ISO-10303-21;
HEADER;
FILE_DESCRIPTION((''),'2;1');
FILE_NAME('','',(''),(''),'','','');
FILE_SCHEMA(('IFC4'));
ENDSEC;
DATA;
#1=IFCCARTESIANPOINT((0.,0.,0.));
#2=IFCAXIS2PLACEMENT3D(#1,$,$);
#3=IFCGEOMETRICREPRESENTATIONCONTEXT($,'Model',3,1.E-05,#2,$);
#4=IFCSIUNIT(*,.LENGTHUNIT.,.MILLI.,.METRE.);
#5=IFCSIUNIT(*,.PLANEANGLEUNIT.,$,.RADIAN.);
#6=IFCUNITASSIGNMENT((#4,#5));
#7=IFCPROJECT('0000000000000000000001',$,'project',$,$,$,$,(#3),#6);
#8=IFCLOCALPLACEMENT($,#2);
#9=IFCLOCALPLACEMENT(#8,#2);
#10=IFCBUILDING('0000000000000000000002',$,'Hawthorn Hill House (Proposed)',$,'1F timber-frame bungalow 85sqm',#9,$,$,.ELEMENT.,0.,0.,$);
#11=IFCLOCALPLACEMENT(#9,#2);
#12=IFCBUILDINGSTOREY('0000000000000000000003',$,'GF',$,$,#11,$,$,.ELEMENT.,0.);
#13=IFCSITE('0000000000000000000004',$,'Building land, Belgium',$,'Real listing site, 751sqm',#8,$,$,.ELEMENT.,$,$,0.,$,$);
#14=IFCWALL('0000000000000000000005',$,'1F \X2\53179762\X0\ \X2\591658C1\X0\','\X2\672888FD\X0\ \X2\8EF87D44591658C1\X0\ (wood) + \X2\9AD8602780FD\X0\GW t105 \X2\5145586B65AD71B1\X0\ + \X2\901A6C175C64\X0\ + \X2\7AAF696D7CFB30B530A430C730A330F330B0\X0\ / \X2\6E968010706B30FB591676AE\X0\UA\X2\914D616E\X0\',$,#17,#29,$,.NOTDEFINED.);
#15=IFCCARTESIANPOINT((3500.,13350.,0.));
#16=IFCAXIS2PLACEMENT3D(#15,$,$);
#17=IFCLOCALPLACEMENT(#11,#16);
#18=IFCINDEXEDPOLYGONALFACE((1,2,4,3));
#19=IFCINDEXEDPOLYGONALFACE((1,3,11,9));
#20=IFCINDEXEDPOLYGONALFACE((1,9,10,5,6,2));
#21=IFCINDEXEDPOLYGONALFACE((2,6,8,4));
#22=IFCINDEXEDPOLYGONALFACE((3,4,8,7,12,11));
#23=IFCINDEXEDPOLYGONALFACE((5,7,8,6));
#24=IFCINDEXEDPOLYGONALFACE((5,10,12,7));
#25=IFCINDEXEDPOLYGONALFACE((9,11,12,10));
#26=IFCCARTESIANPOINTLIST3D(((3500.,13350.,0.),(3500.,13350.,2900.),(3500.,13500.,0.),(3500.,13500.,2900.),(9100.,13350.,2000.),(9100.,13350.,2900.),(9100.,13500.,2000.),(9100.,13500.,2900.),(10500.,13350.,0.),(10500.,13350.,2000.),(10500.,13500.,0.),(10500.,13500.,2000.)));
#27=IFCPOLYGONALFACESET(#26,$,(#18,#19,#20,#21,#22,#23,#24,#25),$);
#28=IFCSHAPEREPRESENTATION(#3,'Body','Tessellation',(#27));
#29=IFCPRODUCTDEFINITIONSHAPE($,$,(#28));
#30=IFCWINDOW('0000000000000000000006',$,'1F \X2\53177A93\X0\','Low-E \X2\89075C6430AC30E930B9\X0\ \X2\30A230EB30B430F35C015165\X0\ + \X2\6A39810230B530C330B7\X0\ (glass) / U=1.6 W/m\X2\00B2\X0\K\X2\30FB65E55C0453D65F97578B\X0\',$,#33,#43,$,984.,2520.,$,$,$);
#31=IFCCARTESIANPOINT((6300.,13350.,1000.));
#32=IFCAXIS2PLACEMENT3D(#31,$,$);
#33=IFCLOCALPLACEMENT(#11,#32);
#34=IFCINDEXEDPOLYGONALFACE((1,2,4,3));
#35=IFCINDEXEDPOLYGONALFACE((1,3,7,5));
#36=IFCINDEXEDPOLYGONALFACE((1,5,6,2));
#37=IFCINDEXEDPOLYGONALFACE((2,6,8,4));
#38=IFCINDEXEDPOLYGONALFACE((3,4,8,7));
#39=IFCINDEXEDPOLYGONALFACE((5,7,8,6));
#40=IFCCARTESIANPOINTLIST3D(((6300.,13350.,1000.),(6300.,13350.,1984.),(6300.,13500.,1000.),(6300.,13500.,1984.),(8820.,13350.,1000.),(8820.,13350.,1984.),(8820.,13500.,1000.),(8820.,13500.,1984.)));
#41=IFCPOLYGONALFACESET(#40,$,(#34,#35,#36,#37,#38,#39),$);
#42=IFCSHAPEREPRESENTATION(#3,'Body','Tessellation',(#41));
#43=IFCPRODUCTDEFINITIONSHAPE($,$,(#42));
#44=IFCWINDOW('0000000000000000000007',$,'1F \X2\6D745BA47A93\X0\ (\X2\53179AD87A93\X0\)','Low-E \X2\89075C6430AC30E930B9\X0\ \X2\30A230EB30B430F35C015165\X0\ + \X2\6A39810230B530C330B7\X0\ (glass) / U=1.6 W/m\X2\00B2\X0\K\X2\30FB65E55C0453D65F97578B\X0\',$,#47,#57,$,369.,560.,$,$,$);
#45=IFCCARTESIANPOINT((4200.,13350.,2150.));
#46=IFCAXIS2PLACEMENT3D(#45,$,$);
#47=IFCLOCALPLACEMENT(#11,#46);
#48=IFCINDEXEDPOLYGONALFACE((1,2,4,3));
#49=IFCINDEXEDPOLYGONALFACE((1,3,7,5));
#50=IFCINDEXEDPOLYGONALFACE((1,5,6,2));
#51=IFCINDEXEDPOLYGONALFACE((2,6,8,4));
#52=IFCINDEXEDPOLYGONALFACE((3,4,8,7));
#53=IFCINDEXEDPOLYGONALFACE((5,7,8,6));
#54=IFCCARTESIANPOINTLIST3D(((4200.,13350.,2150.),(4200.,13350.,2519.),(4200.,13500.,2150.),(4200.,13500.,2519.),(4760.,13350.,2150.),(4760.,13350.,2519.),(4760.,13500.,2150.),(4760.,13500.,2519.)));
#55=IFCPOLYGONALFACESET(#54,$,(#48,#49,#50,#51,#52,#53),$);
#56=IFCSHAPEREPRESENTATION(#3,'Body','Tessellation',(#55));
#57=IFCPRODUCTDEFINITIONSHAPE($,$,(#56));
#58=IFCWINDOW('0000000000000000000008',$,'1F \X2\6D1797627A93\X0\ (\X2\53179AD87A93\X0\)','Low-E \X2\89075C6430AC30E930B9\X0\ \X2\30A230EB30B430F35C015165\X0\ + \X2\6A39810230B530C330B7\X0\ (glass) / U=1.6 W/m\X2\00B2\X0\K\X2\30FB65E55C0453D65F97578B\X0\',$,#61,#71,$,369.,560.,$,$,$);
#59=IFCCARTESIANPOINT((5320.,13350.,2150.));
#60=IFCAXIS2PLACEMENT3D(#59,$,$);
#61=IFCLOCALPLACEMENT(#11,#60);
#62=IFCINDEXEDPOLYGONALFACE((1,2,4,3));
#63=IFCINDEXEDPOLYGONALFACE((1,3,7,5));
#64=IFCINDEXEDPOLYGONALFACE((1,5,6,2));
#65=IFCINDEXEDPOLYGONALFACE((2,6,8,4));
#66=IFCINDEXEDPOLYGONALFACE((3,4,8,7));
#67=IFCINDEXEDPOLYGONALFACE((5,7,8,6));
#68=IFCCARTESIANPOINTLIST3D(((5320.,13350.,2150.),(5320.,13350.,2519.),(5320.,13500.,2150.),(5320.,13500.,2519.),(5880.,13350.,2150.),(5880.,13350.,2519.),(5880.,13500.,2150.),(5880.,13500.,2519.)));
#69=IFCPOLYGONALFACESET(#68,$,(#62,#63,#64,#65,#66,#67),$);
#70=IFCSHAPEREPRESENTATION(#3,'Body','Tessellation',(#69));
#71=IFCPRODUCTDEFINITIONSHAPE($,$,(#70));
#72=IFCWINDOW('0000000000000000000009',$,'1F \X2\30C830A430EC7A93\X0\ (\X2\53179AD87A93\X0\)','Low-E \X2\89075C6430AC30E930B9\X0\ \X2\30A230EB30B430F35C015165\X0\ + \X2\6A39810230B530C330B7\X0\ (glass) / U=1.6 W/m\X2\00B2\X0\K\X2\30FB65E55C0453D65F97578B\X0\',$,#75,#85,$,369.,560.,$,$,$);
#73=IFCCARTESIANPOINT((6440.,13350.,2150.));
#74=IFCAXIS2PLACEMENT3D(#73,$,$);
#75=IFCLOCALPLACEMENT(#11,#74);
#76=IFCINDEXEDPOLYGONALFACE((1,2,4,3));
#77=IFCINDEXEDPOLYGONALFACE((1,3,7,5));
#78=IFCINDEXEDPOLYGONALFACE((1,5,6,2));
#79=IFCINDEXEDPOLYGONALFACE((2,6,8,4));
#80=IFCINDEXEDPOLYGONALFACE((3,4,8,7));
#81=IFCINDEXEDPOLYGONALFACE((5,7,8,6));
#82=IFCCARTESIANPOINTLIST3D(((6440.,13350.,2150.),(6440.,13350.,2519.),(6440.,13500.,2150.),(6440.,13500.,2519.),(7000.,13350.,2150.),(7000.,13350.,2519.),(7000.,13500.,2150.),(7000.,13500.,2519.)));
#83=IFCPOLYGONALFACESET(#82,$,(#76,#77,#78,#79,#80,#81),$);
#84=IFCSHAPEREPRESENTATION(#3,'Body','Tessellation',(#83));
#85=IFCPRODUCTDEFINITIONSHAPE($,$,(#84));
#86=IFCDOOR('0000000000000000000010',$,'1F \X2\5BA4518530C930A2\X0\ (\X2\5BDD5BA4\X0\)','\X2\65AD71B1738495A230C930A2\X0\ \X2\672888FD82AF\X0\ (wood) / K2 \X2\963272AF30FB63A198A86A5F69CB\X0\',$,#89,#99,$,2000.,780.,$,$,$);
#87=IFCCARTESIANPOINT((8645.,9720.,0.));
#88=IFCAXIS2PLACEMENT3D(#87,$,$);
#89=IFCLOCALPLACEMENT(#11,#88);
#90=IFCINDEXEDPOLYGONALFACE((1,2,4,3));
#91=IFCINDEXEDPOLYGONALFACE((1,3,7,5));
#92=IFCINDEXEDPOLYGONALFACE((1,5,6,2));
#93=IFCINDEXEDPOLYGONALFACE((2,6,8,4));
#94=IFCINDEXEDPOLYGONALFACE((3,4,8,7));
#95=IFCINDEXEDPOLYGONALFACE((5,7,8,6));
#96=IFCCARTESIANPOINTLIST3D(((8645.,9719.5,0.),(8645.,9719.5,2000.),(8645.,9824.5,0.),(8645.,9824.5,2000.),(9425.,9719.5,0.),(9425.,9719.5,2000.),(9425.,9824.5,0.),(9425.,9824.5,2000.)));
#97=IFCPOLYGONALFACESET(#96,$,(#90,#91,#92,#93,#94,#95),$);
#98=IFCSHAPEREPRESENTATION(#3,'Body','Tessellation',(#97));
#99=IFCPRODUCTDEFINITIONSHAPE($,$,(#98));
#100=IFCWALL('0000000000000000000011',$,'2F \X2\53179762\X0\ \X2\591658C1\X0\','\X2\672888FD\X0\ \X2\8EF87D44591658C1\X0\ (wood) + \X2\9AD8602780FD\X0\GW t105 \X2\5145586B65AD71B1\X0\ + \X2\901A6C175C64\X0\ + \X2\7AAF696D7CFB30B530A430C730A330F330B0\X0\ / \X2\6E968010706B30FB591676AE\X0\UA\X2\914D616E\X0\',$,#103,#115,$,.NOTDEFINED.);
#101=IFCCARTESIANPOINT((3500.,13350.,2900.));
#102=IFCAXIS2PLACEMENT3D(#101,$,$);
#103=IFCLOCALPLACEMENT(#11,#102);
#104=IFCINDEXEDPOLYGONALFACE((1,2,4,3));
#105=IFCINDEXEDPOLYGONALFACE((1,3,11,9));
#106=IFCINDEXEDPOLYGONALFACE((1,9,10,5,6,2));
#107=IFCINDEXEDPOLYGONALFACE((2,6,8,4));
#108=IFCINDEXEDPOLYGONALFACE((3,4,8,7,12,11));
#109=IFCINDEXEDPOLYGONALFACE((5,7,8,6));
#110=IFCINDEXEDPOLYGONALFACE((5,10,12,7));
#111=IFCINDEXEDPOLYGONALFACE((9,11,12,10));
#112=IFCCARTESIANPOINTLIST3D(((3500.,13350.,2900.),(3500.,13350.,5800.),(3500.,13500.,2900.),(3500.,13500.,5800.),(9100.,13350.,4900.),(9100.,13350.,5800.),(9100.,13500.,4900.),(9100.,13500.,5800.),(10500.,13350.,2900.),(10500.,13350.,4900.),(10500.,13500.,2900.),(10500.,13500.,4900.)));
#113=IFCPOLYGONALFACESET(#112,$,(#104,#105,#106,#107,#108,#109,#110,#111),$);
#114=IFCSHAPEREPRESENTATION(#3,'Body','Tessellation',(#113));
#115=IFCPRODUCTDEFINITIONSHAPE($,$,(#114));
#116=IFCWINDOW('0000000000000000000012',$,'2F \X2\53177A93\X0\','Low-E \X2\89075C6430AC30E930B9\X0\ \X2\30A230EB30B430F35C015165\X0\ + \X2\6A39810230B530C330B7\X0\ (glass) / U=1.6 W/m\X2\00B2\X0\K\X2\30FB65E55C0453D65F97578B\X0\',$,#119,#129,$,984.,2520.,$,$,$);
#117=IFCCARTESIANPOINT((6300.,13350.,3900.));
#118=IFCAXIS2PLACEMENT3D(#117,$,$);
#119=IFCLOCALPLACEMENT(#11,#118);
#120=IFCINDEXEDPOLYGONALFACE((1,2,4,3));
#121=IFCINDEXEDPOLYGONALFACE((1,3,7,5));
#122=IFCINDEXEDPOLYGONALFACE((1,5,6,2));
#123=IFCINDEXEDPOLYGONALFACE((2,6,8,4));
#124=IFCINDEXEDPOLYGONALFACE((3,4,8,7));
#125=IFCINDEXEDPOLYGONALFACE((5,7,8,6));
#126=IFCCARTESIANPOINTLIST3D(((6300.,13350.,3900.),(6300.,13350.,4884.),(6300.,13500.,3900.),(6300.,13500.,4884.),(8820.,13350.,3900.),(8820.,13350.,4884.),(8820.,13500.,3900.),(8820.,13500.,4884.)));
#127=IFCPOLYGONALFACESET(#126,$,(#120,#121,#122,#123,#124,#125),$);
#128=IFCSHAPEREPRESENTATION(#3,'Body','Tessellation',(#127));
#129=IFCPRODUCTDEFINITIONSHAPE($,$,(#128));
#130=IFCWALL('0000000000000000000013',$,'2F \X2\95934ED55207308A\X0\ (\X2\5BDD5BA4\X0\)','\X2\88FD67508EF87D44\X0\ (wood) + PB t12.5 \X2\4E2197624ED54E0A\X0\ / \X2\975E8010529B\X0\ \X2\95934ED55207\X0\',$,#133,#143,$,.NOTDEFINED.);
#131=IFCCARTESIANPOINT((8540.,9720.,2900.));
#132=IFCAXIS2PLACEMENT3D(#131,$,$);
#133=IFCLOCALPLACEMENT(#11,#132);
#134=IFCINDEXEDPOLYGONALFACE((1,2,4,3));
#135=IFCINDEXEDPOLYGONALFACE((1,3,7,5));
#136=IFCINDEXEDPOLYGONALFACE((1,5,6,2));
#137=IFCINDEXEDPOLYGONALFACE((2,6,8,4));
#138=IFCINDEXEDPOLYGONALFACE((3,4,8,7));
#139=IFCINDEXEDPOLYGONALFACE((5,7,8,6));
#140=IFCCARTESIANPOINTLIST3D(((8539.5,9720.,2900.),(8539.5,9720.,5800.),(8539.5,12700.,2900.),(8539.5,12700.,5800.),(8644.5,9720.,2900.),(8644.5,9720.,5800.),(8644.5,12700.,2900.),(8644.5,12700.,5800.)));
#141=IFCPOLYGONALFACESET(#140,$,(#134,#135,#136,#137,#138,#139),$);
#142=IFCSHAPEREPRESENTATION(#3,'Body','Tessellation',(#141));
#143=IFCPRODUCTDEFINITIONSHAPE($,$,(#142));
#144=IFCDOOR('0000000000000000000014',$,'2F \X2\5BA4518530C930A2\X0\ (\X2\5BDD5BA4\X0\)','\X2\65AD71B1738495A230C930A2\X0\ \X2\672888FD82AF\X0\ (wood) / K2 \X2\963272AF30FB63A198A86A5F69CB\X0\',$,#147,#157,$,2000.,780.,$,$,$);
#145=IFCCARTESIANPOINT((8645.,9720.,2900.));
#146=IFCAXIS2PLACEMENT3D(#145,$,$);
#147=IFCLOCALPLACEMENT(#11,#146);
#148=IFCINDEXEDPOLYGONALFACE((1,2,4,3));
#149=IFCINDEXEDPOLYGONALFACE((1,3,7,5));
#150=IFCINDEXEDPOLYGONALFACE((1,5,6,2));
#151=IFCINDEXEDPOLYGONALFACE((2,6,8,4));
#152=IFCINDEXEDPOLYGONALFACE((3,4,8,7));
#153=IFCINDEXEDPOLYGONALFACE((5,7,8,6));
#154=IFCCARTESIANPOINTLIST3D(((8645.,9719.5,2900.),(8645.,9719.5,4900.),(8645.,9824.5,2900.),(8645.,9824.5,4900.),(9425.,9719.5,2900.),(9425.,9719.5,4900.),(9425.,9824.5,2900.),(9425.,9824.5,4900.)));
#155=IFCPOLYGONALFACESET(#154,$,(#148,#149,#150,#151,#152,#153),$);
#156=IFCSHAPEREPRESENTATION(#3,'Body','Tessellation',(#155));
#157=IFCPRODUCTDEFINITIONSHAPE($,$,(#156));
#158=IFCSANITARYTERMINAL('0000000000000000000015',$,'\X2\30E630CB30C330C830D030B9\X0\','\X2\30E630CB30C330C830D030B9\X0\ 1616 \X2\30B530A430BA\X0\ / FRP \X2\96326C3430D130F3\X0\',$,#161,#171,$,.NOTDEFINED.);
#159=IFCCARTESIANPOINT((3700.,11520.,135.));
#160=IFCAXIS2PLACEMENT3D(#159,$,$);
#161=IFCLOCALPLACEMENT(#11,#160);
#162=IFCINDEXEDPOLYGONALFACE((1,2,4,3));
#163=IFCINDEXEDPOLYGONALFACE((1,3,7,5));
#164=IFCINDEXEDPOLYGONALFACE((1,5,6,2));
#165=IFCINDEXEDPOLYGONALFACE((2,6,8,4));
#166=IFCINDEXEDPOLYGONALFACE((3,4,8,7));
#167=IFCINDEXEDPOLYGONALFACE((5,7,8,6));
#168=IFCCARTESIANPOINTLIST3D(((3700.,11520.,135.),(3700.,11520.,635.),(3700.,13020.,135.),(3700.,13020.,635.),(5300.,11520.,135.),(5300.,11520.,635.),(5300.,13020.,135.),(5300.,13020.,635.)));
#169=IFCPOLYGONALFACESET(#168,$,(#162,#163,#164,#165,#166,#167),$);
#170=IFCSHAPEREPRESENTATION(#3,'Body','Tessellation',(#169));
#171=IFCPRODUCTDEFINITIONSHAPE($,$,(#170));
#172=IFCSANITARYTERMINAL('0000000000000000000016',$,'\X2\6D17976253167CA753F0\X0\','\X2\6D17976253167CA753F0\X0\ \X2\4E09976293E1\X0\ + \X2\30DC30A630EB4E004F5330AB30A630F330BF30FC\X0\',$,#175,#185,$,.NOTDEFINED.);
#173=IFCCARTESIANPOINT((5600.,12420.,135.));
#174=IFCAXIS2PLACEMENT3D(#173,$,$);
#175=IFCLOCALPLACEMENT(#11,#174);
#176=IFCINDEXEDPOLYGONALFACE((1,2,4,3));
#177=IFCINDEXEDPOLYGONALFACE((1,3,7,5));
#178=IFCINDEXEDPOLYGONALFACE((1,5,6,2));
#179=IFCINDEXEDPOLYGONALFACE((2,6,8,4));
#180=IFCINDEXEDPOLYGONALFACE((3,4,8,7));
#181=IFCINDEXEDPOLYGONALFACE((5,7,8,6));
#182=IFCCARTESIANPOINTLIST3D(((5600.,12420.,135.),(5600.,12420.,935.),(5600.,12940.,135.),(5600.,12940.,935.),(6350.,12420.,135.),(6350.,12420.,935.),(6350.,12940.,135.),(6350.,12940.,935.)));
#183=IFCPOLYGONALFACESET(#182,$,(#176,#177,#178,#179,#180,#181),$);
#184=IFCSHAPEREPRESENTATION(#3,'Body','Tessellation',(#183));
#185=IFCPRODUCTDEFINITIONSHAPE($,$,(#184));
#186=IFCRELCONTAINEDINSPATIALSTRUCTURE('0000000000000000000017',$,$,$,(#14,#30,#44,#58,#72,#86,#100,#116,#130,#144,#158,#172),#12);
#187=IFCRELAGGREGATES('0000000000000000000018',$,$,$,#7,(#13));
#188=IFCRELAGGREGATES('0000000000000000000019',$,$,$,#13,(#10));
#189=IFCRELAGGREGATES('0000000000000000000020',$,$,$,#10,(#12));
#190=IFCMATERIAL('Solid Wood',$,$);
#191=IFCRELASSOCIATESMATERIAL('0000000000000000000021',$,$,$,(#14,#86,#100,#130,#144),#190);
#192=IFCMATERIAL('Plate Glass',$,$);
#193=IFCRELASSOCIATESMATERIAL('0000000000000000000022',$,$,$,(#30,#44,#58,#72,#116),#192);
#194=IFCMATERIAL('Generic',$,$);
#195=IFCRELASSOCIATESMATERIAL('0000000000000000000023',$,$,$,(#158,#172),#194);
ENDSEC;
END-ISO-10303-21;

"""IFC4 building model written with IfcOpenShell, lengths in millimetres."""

from ifc_helpers import new_model, si_unit, frame, frame_2d, origin, place, context, project, spatial, rectangle, extrude, material, element, fill, save


model = new_model("IFC4")

# Units and contexts
model_context = context("Model", 3, precision=1e-05, world=origin())
ifc_project = project(units=[si_unit("LENGTHUNIT", "METRE", prefix="MILLI"), si_unit("PLANEANGLEUNIT", "RADIAN")], contexts=[model_context])

# Site, building, storey
site_placement = place(None, origin())
site = spatial("IfcSite", under=ifc_project, at=site_placement, Name="Building land, Belgium", ObjectType="Real listing site, 751sqm", CompositionType="ELEMENT", RefElevation=0.0)
building_placement = place(site_placement, origin())
building = spatial("IfcBuilding", under=site, at=building_placement, Name="Hawthorn Hill House (Proposed)", ObjectType="1F timber-frame bungalow 85sqm", CompositionType="ELEMENT", ElevationOfRefHeight=0.0, ElevationOfTerrain=0.0)
storey_placement = place(building_placement, origin())
storey = spatial("IfcBuildingStorey", under=building, at=storey_placement, Name="GF", CompositionType="ELEMENT", Elevation=0.0)

# Wall, openings, windows
ifc_material_1 = material(Name="Solid Wood")
wall_1_placement = place(storey_placement, frame((3500.0, 13350.0, 0.0)))
wall_1 = element("IfcWall", 1, at=wall_1_placement, inside=storey, material=ifc_material_1, Name="1F 北面 外壁", Description="木製 軸組外壁 (wood) + 高性能GW t105 充填断熱 + 通気層 + 窯業系サイディング / 準耐火・外皮UA配慮", PredefinedType="NOTDEFINED", context=model_context, shape_type="SweptSolid", body=[
    extrude(rectangle(XDim=7000.0, YDim=150.0, at=frame_2d((3500.0, 75.0))), frame((3500.0, 13350.0, 0.0)), (0.0, 0.0, 1.0), 2900.0),
])
opening_1_placement = place(storey_placement, frame((6300.0, 13350.0, 1000.0)))
opening_1 = element("IfcOpeningElement", 2, at=opening_1_placement, cuts=wall_1, PredefinedType="NOTDEFINED", context=model_context, shape_type="SweptSolid", body=[
    extrude(rectangle(XDim=2520.0, YDim=150.0, at=frame_2d((1260.0, 75.0))), frame((6300.0, 13350.0, 1000.0)), (0.0, 0.0, 1.0), 984.0),
])
opening_2_placement = place(storey_placement, frame((4200.0, 13350.0, 2150.0)))
opening_2 = element("IfcOpeningElement", 3, at=opening_2_placement, cuts=wall_1, PredefinedType="NOTDEFINED", context=model_context, shape_type="SweptSolid", body=[
    extrude(rectangle(XDim=560.0, YDim=150.0, at=frame_2d((280.0, 75.0))), frame((4200.0, 13350.0, 2150.0)), (0.0, 0.0, 1.0), 369.0),
])
opening_3_placement = place(storey_placement, frame((5320.0, 13350.0, 2150.0)))
opening_3 = element("IfcOpeningElement", 4, at=opening_3_placement, cuts=wall_1, PredefinedType="NOTDEFINED", context=model_context, shape_type="SweptSolid", body=[
    extrude(rectangle(XDim=560.0, YDim=150.0, at=frame_2d((280.0, 75.0))), frame((5320.0, 13350.0, 2150.0)), (0.0, 0.0, 1.0), 369.0),
])
opening_4_placement = place(storey_placement, frame((6440.0, 13350.0, 2150.0)))
opening_4 = element("IfcOpeningElement", 5, at=opening_4_placement, cuts=wall_1, PredefinedType="NOTDEFINED", context=model_context, shape_type="SweptSolid", body=[
    extrude(rectangle(XDim=560.0, YDim=150.0, at=frame_2d((280.0, 75.0))), frame((6440.0, 13350.0, 2150.0)), (0.0, 0.0, 1.0), 369.0),
])
ifc_material_2 = material(Name="Plate Glass")
window_1_placement = place(storey_placement, frame((6300.0, 13350.0, 1000.0)))
window_1 = element("IfcWindow", 6, at=window_1_placement, inside=storey, material=ifc_material_2, Name="1F 北窓", Description="Low-E 複層ガラス アルゴン封入 + 樹脂サッシ (glass) / U=1.6 W/m²K・日射取得型", OverallHeight=984.0, OverallWidth=2520.0, context=model_context, shape_type="SweptSolid", body=[
    extrude(rectangle(XDim=2520.0, YDim=150.0, at=frame_2d((1260.0, 75.0))), frame((6300.0, 13350.0, 1000.0)), (0.0, 0.0, 1.0), 984.0),
])
fill(opening_1, window_1)
window_2_placement = place(storey_placement, frame((4200.0, 13350.0, 2150.0)))
window_2 = element("IfcWindow", 7, at=window_2_placement, inside=storey, material=ifc_material_2, Name="1F 浴室窓 (北高窓)", Description="Low-E 複層ガラス アルゴン封入 + 樹脂サッシ (glass) / U=1.6 W/m²K・日射取得型", OverallHeight=369.0, OverallWidth=560.0, context=model_context, shape_type="SweptSolid", body=[
    extrude(rectangle(XDim=560.0, YDim=150.0, at=frame_2d((280.0, 75.0))), frame((4200.0, 13350.0, 2150.0)), (0.0, 0.0, 1.0), 369.0),
])
fill(opening_2, window_2)
window_3_placement = place(storey_placement, frame((5320.0, 13350.0, 2150.0)))
window_3 = element("IfcWindow", 8, at=window_3_placement, inside=storey, material=ifc_material_2, Name="1F 洗面窓 (北高窓)", Description="Low-E 複層ガラス アルゴン封入 + 樹脂サッシ (glass) / U=1.6 W/m²K・日射取得型", OverallHeight=369.0, OverallWidth=560.0, context=model_context, shape_type="SweptSolid", body=[
    extrude(rectangle(XDim=560.0, YDim=150.0, at=frame_2d((280.0, 75.0))), frame((5320.0, 13350.0, 2150.0)), (0.0, 0.0, 1.0), 369.0),
])
fill(opening_3, window_3)
window_4_placement = place(storey_placement, frame((6440.0, 13350.0, 2150.0)))
window_4 = element("IfcWindow", 9, at=window_4_placement, inside=storey, material=ifc_material_2, Name="1F トイレ窓 (北高窓)", Description="Low-E 複層ガラス アルゴン封入 + 樹脂サッシ (glass) / U=1.6 W/m²K・日射取得型", OverallHeight=369.0, OverallWidth=560.0, context=model_context, shape_type="SweptSolid", body=[
    extrude(rectangle(XDim=560.0, YDim=150.0, at=frame_2d((280.0, 75.0))), frame((6440.0, 13350.0, 2150.0)), (0.0, 0.0, 1.0), 369.0),
])
fill(opening_4, window_4)

# Door
door_1_placement = place(storey_placement, frame((8645.0, 9720.0, 0.0)))
element("IfcDoor", 10, at=door_1_placement, inside=storey, material=ifc_material_1, Name="1F 室内ドア (寝室)", Description="断熱玄関ドア 木製芯 (wood) / K2 防犯・採風機構", OverallHeight=2000.0, OverallWidth=780.0, context=model_context, shape_type="SweptSolid", body=[
    extrude(rectangle(XDim=780.0, YDim=105.0, at=frame_2d((390.0, 52.0))), frame((8645.0, 9720.0, 0.0)), (0.0, 0.0, 1.0), 2000.0),
])

# Wall, opening, window
wall_2_placement = place(storey_placement, frame((3500.0, 13350.0, 2900.0)))
wall_2 = element("IfcWall", 11, at=wall_2_placement, inside=storey, material=ifc_material_1, Name="2F 北面 外壁", Description="木製 軸組外壁 (wood) + 高性能GW t105 充填断熱 + 通気層 + 窯業系サイディング / 準耐火・外皮UA配慮", PredefinedType="NOTDEFINED", context=model_context, shape_type="SweptSolid", body=[
    extrude(rectangle(XDim=7000.0, YDim=150.0, at=frame_2d((3500.0, 75.0))), frame((3500.0, 13350.0, 2900.0)), (0.0, 0.0, 1.0), 2900.0),
])
opening_5_placement = place(storey_placement, frame((6300.0, 13350.0, 3900.0)))
opening_5 = element("IfcOpeningElement", 12, at=opening_5_placement, cuts=wall_2, PredefinedType="NOTDEFINED", context=model_context, shape_type="SweptSolid", body=[
    extrude(rectangle(XDim=2520.0, YDim=150.0, at=frame_2d((1260.0, 75.0))), frame((6300.0, 13350.0, 3900.0)), (0.0, 0.0, 1.0), 984.0),
])
window_5_placement = place(storey_placement, frame((6300.0, 13350.0, 3900.0)))
window_5 = element("IfcWindow", 13, at=window_5_placement, inside=storey, material=ifc_material_2, Name="2F 北窓", Description="Low-E 複層ガラス アルゴン封入 + 樹脂サッシ (glass) / U=1.6 W/m²K・日射取得型", OverallHeight=984.0, OverallWidth=2520.0, context=model_context, shape_type="SweptSolid", body=[
    extrude(rectangle(XDim=2520.0, YDim=150.0, at=frame_2d((1260.0, 75.0))), frame((6300.0, 13350.0, 3900.0)), (0.0, 0.0, 1.0), 984.0),
])
fill(opening_5, window_5)

# Wall
wall_3_placement = place(storey_placement, frame((8540.0, 9720.0, 2900.0)))
element("IfcWall", 14, at=wall_3_placement, inside=storey, material=ifc_material_1, Name="2F 間仕切り (寝室)", Description="製材軸組 (wood) + PB t12.5 両面仕上 / 非耐力 間仕切", PredefinedType="NOTDEFINED", context=model_context, shape_type="SweptSolid", body=[
    extrude(rectangle(XDim=105.0, YDim=2980.0, at=frame_2d((52.0, 1490.0))), frame((8540.0, 9720.0, 2900.0)), (0.0, 0.0, 1.0), 2900.0),
])

# Door
door_2_placement = place(storey_placement, frame((8645.0, 9720.0, 2900.0)))
element("IfcDoor", 15, at=door_2_placement, inside=storey, material=ifc_material_1, Name="2F 室内ドア (寝室)", Description="断熱玄関ドア 木製芯 (wood) / K2 防犯・採風機構", OverallHeight=2000.0, OverallWidth=780.0, context=model_context, shape_type="SweptSolid", body=[
    extrude(rectangle(XDim=780.0, YDim=105.0, at=frame_2d((390.0, 52.0))), frame((8645.0, 9720.0, 2900.0)), (0.0, 0.0, 1.0), 2000.0),
])

# Sanitary terminals
ifc_material_3 = material(Name="Generic")
sanitary_terminal_1_placement = place(storey_placement, frame((3700.0, 11520.0, 135.0)))
element("IfcSanitaryTerminal", 16, at=sanitary_terminal_1_placement, inside=storey, material=ifc_material_3, Name="ユニットバス", Description="ユニットバス 1616 サイズ / FRP 防水パン", PredefinedType="NOTDEFINED", context=model_context, shape_type="SweptSolid", body=[
    extrude(rectangle(XDim=1600.0, YDim=1500.0, at=frame_2d((800.0, 750.0))), frame((3700.0, 11520.0, 135.0)), (0.0, 0.0, 1.0), 500.0),
])
sanitary_terminal_2_placement = place(storey_placement, frame((5600.0, 12420.0, 135.0)))
element("IfcSanitaryTerminal", 17, at=sanitary_terminal_2_placement, inside=storey, material=ifc_material_3, Name="洗面化粧台", Description="洗面化粧台 三面鏡 + ボウル一体カウンター", PredefinedType="NOTDEFINED", context=model_context, shape_type="SweptSolid", body=[
    extrude(rectangle(XDim=750.0, YDim=520.0, at=frame_2d((375.0, 260.0))), frame((5600.0, 12420.0, 135.0)), (0.0, 0.0, 1.0), 800.0),
])

save(model, "model.ifc")
